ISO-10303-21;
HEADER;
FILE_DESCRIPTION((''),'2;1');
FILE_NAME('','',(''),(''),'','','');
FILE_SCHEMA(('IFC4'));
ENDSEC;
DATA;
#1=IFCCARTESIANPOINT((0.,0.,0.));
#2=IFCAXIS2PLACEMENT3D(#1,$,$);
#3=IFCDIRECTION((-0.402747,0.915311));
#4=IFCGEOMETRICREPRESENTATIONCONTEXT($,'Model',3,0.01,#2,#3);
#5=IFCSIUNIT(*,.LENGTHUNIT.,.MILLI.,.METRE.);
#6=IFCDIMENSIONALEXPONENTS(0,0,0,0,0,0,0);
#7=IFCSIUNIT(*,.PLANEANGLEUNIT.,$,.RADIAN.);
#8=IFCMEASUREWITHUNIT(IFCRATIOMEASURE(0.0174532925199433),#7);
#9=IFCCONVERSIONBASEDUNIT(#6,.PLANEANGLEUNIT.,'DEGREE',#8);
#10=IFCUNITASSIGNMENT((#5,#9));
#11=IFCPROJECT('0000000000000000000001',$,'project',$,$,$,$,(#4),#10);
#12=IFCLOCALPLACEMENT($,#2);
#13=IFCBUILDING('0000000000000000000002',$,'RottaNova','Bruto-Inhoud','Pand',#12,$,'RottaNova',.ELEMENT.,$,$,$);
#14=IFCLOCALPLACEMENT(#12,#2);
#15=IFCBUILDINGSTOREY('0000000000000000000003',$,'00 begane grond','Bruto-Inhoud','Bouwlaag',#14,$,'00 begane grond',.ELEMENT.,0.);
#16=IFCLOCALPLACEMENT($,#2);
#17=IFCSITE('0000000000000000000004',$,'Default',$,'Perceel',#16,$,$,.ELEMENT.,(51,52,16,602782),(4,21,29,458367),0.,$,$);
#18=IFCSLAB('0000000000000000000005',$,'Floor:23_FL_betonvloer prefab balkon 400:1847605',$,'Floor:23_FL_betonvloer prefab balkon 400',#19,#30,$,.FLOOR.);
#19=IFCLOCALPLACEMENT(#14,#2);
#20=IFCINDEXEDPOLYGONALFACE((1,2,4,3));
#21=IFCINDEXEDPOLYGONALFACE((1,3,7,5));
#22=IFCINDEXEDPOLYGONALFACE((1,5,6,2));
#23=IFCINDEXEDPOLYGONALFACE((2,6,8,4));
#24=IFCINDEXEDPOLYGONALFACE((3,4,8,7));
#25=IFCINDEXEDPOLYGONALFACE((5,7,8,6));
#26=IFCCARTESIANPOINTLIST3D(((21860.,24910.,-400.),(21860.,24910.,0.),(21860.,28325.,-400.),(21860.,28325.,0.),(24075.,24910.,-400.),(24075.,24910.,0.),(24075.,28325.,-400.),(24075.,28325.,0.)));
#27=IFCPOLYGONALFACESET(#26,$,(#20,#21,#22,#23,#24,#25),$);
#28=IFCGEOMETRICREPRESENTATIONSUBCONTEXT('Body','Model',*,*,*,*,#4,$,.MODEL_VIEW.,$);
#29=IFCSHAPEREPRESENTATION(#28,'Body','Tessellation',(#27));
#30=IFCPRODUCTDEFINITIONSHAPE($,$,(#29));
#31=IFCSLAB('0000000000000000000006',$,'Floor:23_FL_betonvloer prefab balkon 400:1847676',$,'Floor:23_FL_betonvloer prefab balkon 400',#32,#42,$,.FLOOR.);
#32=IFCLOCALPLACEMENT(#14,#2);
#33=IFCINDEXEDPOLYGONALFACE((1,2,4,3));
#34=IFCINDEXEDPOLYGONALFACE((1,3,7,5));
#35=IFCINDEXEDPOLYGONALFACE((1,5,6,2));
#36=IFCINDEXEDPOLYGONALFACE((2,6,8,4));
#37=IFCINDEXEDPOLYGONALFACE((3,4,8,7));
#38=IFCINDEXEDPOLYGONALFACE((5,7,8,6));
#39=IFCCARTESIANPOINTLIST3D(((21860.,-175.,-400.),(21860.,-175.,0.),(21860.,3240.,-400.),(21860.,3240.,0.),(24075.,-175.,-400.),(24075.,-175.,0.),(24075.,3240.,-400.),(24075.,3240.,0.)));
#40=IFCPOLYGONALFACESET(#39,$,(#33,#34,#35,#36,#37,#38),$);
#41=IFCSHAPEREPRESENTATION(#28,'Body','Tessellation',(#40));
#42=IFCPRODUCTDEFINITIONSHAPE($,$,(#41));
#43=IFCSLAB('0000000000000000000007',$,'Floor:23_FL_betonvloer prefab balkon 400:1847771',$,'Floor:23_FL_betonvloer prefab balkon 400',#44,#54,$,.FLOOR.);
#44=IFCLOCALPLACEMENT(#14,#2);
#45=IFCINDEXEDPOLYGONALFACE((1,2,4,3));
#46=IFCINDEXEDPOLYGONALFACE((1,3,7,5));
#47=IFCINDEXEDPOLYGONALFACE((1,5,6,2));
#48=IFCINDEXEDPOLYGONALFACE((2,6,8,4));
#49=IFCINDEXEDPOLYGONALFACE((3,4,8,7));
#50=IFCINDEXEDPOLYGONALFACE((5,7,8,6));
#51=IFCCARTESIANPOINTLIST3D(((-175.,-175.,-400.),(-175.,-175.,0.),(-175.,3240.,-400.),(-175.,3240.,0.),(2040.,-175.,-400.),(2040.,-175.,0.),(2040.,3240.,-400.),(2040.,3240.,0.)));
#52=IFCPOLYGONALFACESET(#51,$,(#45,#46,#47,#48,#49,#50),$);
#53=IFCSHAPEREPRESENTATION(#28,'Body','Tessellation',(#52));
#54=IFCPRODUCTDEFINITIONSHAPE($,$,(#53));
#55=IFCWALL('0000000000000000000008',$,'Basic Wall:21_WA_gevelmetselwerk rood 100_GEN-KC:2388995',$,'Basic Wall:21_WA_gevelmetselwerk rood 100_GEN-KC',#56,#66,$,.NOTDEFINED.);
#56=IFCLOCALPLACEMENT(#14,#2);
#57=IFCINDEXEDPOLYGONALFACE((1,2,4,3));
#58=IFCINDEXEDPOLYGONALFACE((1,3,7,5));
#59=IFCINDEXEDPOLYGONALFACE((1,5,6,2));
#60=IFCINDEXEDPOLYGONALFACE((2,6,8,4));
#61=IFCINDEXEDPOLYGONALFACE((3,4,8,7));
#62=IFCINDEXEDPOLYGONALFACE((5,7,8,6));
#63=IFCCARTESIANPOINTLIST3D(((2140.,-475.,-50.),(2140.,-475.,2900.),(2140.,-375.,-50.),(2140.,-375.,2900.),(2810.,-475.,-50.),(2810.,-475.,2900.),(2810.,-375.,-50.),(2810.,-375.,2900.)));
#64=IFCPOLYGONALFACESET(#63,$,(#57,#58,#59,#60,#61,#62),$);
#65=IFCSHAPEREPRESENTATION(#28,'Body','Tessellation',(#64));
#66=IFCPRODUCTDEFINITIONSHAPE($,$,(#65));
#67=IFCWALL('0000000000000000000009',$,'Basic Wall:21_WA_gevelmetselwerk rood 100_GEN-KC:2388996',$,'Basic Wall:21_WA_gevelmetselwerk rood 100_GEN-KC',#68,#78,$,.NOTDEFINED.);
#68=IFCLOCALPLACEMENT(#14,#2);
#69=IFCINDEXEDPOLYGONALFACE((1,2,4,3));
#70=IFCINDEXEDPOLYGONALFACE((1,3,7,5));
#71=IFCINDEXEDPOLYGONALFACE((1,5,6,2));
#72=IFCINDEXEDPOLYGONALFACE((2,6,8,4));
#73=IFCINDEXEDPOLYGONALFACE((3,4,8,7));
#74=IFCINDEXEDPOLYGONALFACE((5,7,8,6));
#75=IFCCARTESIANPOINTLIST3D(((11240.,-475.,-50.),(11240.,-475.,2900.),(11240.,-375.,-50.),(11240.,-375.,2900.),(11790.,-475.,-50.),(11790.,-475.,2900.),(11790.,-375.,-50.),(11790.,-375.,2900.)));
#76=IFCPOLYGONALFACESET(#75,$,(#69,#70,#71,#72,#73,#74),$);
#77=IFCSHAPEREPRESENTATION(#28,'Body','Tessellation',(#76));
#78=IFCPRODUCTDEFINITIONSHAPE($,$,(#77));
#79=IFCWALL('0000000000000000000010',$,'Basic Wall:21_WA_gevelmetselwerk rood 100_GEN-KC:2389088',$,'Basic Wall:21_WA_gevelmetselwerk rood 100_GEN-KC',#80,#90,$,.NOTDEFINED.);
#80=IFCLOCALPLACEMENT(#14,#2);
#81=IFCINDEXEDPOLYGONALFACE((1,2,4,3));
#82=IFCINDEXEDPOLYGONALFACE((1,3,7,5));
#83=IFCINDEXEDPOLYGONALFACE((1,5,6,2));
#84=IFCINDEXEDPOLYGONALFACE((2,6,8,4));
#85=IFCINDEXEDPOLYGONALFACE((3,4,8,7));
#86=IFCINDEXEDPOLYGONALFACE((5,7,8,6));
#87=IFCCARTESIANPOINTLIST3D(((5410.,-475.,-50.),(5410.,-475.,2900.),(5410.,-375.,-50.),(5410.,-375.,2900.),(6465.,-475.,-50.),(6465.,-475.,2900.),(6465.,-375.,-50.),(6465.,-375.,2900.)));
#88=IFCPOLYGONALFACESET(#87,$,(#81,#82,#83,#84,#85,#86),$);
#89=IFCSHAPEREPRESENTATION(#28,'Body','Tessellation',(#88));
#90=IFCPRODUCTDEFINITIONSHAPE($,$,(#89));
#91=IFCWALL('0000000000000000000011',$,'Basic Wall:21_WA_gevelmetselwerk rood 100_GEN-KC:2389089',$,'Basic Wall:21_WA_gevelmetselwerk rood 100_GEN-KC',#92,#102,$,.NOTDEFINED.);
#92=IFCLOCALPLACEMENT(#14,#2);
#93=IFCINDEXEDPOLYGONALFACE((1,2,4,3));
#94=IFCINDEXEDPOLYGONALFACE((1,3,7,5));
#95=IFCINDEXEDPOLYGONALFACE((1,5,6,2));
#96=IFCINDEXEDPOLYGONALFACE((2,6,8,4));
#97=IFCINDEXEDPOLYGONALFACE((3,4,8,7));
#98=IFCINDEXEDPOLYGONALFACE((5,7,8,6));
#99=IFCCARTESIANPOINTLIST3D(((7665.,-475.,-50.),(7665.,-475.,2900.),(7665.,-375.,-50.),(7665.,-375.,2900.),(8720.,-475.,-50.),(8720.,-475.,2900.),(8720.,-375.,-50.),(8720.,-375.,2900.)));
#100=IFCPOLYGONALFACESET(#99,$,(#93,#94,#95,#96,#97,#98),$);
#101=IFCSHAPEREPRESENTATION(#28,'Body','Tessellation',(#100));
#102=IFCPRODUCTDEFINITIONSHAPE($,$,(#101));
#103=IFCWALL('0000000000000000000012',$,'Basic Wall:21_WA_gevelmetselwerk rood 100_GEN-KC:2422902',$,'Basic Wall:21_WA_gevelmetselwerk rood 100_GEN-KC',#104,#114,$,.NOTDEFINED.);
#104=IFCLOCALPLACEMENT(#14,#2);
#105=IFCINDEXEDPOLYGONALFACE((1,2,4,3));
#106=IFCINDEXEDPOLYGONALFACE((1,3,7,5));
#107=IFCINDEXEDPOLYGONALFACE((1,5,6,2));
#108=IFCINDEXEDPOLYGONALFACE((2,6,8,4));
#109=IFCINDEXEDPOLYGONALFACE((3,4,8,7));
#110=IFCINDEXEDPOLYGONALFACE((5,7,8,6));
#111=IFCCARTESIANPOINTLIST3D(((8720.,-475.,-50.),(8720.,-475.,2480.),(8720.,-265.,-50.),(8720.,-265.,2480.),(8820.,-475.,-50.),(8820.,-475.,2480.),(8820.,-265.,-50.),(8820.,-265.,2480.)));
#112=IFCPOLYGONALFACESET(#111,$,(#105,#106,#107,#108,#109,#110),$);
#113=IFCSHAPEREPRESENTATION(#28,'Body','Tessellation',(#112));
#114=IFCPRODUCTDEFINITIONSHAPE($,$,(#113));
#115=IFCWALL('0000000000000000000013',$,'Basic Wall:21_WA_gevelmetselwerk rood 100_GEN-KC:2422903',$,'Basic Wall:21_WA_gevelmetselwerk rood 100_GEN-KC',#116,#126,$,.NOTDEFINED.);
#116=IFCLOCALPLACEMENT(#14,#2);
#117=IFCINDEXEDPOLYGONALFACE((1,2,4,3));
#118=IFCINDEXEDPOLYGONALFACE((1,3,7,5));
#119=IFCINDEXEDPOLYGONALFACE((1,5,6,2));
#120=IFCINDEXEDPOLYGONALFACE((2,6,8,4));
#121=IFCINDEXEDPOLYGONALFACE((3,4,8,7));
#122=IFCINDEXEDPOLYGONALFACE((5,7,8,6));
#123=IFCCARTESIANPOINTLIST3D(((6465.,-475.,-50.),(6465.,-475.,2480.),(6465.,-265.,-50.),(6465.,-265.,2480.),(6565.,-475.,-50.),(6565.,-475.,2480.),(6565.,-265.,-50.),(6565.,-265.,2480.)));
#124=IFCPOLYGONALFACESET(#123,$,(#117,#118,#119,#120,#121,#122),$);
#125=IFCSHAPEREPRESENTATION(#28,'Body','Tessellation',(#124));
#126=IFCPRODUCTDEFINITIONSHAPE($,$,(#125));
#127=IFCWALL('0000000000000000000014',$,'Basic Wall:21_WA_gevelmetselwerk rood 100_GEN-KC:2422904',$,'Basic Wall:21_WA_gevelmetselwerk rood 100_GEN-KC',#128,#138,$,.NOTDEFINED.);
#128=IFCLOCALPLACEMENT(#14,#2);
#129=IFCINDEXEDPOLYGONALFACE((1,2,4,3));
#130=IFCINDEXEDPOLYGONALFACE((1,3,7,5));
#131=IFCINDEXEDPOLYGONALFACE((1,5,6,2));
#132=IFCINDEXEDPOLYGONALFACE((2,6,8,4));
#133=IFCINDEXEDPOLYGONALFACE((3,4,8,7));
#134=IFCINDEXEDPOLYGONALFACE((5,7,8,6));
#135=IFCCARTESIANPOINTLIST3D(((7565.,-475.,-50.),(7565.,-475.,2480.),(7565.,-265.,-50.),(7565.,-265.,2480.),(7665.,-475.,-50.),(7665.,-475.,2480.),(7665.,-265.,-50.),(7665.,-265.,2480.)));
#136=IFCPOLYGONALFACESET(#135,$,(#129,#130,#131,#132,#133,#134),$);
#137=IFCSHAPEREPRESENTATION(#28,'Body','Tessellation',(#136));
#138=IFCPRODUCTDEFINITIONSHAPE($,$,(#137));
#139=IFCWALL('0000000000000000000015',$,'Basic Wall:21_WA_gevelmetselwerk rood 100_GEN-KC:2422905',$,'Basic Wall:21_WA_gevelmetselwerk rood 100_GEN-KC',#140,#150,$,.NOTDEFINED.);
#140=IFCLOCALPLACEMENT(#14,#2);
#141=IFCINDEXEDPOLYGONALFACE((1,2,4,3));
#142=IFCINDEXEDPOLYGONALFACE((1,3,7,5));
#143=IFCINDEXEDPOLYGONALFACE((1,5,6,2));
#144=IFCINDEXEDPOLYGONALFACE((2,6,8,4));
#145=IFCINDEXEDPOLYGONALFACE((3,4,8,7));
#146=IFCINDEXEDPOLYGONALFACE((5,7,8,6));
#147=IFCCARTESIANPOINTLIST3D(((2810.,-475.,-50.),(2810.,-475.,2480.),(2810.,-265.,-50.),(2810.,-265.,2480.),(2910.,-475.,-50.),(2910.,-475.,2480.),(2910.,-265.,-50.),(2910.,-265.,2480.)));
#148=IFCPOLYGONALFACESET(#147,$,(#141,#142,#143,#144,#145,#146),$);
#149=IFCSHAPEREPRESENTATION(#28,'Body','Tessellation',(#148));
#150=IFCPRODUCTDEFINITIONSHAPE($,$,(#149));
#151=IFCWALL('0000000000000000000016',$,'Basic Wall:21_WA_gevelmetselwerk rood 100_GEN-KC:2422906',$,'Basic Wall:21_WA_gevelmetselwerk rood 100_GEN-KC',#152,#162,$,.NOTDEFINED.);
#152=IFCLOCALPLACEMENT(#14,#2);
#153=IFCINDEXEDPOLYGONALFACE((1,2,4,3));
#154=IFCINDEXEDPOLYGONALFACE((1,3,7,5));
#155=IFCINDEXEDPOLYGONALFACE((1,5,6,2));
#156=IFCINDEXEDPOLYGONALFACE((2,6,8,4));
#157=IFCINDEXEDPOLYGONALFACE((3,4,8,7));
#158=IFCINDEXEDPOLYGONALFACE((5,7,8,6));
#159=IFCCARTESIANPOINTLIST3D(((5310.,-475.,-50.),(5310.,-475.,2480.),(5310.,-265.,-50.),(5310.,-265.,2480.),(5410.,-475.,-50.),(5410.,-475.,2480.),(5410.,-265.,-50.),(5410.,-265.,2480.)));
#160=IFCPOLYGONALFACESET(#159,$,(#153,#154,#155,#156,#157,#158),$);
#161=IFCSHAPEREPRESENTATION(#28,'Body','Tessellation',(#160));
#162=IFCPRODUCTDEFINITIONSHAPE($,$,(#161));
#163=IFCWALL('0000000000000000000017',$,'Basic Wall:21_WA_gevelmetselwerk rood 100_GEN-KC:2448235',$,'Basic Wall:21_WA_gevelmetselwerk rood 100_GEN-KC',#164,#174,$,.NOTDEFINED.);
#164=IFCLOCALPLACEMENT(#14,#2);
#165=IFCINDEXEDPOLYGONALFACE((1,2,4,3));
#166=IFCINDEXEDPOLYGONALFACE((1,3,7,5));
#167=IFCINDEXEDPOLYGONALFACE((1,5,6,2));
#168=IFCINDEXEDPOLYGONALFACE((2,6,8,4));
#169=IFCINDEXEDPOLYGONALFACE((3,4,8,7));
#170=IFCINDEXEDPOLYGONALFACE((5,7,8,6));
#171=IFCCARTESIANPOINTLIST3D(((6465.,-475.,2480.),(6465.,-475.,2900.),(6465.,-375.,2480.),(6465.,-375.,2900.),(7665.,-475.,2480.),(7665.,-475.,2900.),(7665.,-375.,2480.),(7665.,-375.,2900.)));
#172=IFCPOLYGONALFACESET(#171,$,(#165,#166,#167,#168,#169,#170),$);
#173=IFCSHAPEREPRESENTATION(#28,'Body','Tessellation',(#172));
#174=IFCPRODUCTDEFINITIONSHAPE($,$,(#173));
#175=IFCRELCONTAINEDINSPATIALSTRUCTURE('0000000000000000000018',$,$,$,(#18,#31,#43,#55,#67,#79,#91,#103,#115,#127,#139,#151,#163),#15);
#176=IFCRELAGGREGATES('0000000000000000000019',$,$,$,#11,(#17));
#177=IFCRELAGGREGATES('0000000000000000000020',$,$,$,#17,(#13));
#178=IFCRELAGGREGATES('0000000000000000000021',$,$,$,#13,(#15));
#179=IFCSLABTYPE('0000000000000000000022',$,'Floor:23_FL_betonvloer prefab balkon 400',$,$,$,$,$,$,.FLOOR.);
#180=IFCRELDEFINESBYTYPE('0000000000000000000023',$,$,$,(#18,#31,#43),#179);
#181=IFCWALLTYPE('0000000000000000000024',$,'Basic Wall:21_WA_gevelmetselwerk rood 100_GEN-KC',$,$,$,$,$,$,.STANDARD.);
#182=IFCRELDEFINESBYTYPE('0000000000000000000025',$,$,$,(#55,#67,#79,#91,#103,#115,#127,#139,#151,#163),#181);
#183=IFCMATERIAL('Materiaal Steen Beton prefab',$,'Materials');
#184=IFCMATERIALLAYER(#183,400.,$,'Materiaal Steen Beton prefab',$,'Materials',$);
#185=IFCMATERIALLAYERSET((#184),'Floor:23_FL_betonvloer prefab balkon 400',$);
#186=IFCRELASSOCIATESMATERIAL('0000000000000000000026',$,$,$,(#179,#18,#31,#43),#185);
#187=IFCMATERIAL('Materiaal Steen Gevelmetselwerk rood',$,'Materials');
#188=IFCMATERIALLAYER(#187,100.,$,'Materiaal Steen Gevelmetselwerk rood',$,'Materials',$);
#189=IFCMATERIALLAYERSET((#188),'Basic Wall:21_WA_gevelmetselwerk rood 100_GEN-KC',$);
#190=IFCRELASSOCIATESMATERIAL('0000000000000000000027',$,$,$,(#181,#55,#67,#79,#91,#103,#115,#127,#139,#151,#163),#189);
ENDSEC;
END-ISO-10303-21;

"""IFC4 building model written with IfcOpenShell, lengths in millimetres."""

from ifc_helpers import new_model, entity, si_unit, converted_unit, direction, frame, frame_2d, origin, place, context, subcontext, project, spatial, rectangle, extrude, material, layer, layer_set, layer_usage, type_object, element, save


model = new_model("IFC4")

# Units and contexts
model_context = context("Model", 3, precision=0.01, world=origin(), true_north=direction((-0.402747, 0.915311)))
body_context = subcontext(model_context, "Body", "Model", "MODEL_VIEW")
ifc_project = project(units=[si_unit("LENGTHUNIT", "METRE", prefix="MILLI"), converted_unit("PLANEANGLEUNIT", "DEGREE", entity("IfcRatioMeasure", 0.0174532925199433), si_unit("PLANEANGLEUNIT", "RADIAN"), dimensions=[0, 0, 0, 0, 0, 0, 0])], contexts=[model_context])

# Site, building, storey
site_placement = place(None, origin())
site = spatial("IfcSite", under=ifc_project, at=site_placement, Name="Default", ObjectType="Perceel", CompositionType="ELEMENT", RefLatitude=(51, 52, 16, 602782), RefLongitude=(4, 21, 29, 458367), RefElevation=0.0)
building_placement = place(None, origin())
building = spatial("IfcBuilding", under=site, at=building_placement, Name="RottaNova", Description="Bruto-Inhoud", ObjectType="Pand", LongName="RottaNova", CompositionType="ELEMENT")
storey_placement = place(building_placement, origin())
storey = spatial("IfcBuildingStorey", under=building, at=storey_placement, Name="00 begane grond", Description="Bruto-Inhoud", ObjectType="Bouwlaag", LongName="00 begane grond", CompositionType="ELEMENT", Elevation=0.0)

# Slabs
ifc_material_1 = material(Name="Materiaal Steen Beton prefab", Category="Materials")
ifc_layer_1 = layer(ifc_material_1, 400.0, Name="Materiaal Steen Beton prefab", Category="Materials")
ifc_layer_set_1 = layer_set([ifc_layer_1], Name="Floor:23_FL_betonvloer prefab balkon 400")
ifc_layer_usage = layer_usage(ifc_layer_set_1, "AXIS3", "POSITIVE", 0.0)
slab_type = type_object("IfcSlabType", Name="Floor:23_FL_betonvloer prefab balkon 400", PredefinedType="FLOOR", material=ifc_layer_set_1)
slab_1_placement = place(storey_placement, origin())
element("IfcSlab", 1, at=slab_1_placement, inside=storey, type_object=slab_type, material=ifc_layer_usage, Name="Floor:23_FL_betonvloer prefab balkon 400:1847605", ObjectType="Floor:23_FL_betonvloer prefab balkon 400", PredefinedType="FLOOR", context=body_context, shape_type="SweptSolid", body=[
    extrude(rectangle(XDim=3415.0, YDim=2215.0, at=frame_2d((0.0, 0.0), x_axis=(1.0, 0.0))), frame((22967.5, 26617.5, 0.0), z_axis=(0.0, 0.0, -1.0), x_axis=(0.0, 1.0, 0.0)), (0.0, 0.0, 1.0), 400.0),
])
slab_2_placement = place(storey_placement, origin())
element("IfcSlab", 2, at=slab_2_placement, inside=storey, type_object=slab_type, material=ifc_layer_usage, Name="Floor:23_FL_betonvloer prefab balkon 400:1847676", ObjectType="Floor:23_FL_betonvloer prefab balkon 400", PredefinedType="FLOOR", context=body_context, shape_type="SweptSolid", body=[
    extrude(rectangle(XDim=3415.0, YDim=2215.0, at=frame_2d((0.0, 0.0), x_axis=(1.0, 0.0))), frame((22967.5, 1532.5, 0.0), z_axis=(0.0, 0.0, -1.0), x_axis=(0.0, 1.0, 0.0)), (0.0, 0.0, 1.0), 400.0),
])
slab_3_placement = place(storey_placement, origin())
element("IfcSlab", 3, at=slab_3_placement, inside=storey, type_object=slab_type, material=ifc_layer_usage, Name="Floor:23_FL_betonvloer prefab balkon 400:1847771", ObjectType="Floor:23_FL_betonvloer prefab balkon 400", PredefinedType="FLOOR", context=body_context, shape_type="SweptSolid", body=[
    extrude(rectangle(XDim=3415.0, YDim=2215.0, at=frame_2d((0.0, 0.0), x_axis=(1.0, 0.0))), frame((932.5, 1532.5, 0.0), z_axis=(0.0, 0.0, -1.0), x_axis=(0.0, 1.0, 0.0)), (0.0, 0.0, 1.0), 400.0),
])

# Walls
ifc_material_2 = material(Name="Materiaal Steen Gevelmetselwerk rood", Category="Materials")
ifc_layer_2 = layer(ifc_material_2, 100.0, Name="Materiaal Steen Gevelmetselwerk rood", Category="Materials")
ifc_layer_set_2 = layer_set([ifc_layer_2], Name="Basic Wall:21_WA_gevelmetselwerk rood 100_GEN-KC")
wall_type_1 = type_object("IfcWallType", Name="Basic Wall:21_WA_gevelmetselwerk rood 100_GEN-KC", PredefinedType="STANDARD", material=ifc_layer_set_2)
wall_1_placement = place(storey_placement, frame((2140.0, -425.0, -50.0)))
element("IfcWall", 4, at=wall_1_placement, inside=storey, type_object=wall_type_1, material=ifc_layer_set_2, Name="Basic Wall:21_WA_gevelmetselwerk rood 100_GEN-KC:2388995", ObjectType="Basic Wall:21_WA_gevelmetselwerk rood 100_GEN-KC", PredefinedType="NOTDEFINED", context=body_context, shape_type="SweptSolid", body=[
    extrude(rectangle(XDim=670.0, YDim=100.0, at=frame_2d((335.0, 0.0), x_axis=(-1.0, 0.0))), origin(), (0.0, 0.0, 1.0), 2950.0),
])
wall_2_placement = place(storey_placement, frame((11240.0, -425.0, -50.0)))
element("IfcWall", 5, at=wall_2_placement, inside=storey, type_object=wall_type_1, material=ifc_layer_set_2, Name="Basic Wall:21_WA_gevelmetselwerk rood 100_GEN-KC:2388996", ObjectType="Basic Wall:21_WA_gevelmetselwerk rood 100_GEN-KC", PredefinedType="NOTDEFINED", context=body_context, shape_type="SweptSolid", body=[
    extrude(rectangle(XDim=550.0, YDim=100.0, at=frame_2d((275.0, 0.0), x_axis=(-1.0, 0.0))), origin(), (0.0, 0.0, 1.0), 2950.0),
])
wall_3_placement = place(storey_placement, frame((5410.0, -425.0, -50.0)))
element("IfcWall", 6, at=wall_3_placement, inside=storey, type_object=wall_type_1, material=ifc_layer_set_2, Name="Basic Wall:21_WA_gevelmetselwerk rood 100_GEN-KC:2389088", ObjectType="Basic Wall:21_WA_gevelmetselwerk rood 100_GEN-KC", PredefinedType="NOTDEFINED", context=body_context, shape_type="SweptSolid", body=[
    extrude(rectangle(XDim=1055.0, YDim=100.0, at=frame_2d((527.5, 0.0), x_axis=(-1.0, 0.0))), origin(), (0.0, 0.0, 1.0), 2950.0),
])
wall_4_placement = place(storey_placement, frame((7665.0, -425.0, -50.0)))
element("IfcWall", 7, at=wall_4_placement, inside=storey, type_object=wall_type_1, material=ifc_layer_set_2, Name="Basic Wall:21_WA_gevelmetselwerk rood 100_GEN-KC:2389089", ObjectType="Basic Wall:21_WA_gevelmetselwerk rood 100_GEN-KC", PredefinedType="NOTDEFINED", context=body_context, shape_type="SweptSolid", body=[
    extrude(rectangle(XDim=1055.0, YDim=100.0, at=frame_2d((527.5, 0.0), x_axis=(-1.0, 0.0))), origin(), (0.0, 0.0, 1.0), 2950.0),
])
wall_5_placement = place(storey_placement, frame((8770.0, -265.0, -50.0), z_axis=(0.0, 0.0, 1.0), x_axis=(0.0, -1.0, 0.0)))
element("IfcWall", 8, at=wall_5_placement, inside=storey, type_object=wall_type_1, material=ifc_layer_set_2, Name="Basic Wall:21_WA_gevelmetselwerk rood 100_GEN-KC:2422902", ObjectType="Basic Wall:21_WA_gevelmetselwerk rood 100_GEN-KC", PredefinedType="NOTDEFINED", context=body_context, shape_type="SweptSolid", body=[
    extrude(rectangle(XDim=210.0, YDim=100.0, at=frame_2d((105.0, 0.0), x_axis=(-1.0, 0.0))), origin(), (0.0, 0.0, 1.0), 2530.0),
])
wall_6_placement = place(storey_placement, frame((6515.0, -265.0, -50.0), z_axis=(0.0, 0.0, 1.0), x_axis=(0.0, -1.0, 0.0)))
element("IfcWall", 9, at=wall_6_placement, inside=storey, type_object=wall_type_1, material=ifc_layer_set_2, Name="Basic Wall:21_WA_gevelmetselwerk rood 100_GEN-KC:2422903", ObjectType="Basic Wall:21_WA_gevelmetselwerk rood 100_GEN-KC", PredefinedType="NOTDEFINED", context=body_context, shape_type="SweptSolid", body=[
    extrude(rectangle(XDim=210.0, YDim=100.0, at=frame_2d((105.0, 0.0), x_axis=(-1.0, 0.0))), origin(), (0.0, 0.0, 1.0), 2530.0),
])
wall_7_placement = place(storey_placement, frame((7615.0, -265.0, -50.0), z_axis=(0.0, 0.0, 1.0), x_axis=(0.0, -1.0, 0.0)))
element("IfcWall", 10, at=wall_7_placement, inside=storey, type_object=wall_type_1, material=ifc_layer_set_2, Name="Basic Wall:21_WA_gevelmetselwerk rood 100_GEN-KC:2422904", ObjectType="Basic Wall:21_WA_gevelmetselwerk rood 100_GEN-KC", PredefinedType="NOTDEFINED", context=body_context, shape_type="SweptSolid", body=[
    extrude(rectangle(XDim=210.0, YDim=100.0, at=frame_2d((105.0, 0.0), x_axis=(-1.0, 0.0))), origin(), (0.0, 0.0, 1.0), 2530.0),
])
wall_8_placement = place(storey_placement, frame((2860.0, -265.0, -50.0), z_axis=(0.0, 0.0, 1.0), x_axis=(0.0, -1.0, 0.0)))
element("IfcWall", 11, at=wall_8_placement, inside=storey, type_object=wall_type_1, material=ifc_layer_set_2, Name="Basic Wall:21_WA_gevelmetselwerk rood 100_GEN-KC:2422905", ObjectType="Basic Wall:21_WA_gevelmetselwerk rood 100_GEN-KC", PredefinedType="NOTDEFINED", context=body_context, shape_type="SweptSolid", body=[
    extrude(rectangle(XDim=210.0, YDim=100.0, at=frame_2d((105.0, 0.0), x_axis=(-1.0, 0.0))), origin(), (0.0, 0.0, 1.0), 2530.0),
])
wall_9_placement = place(storey_placement, frame((5360.0, -265.0, -50.0), z_axis=(0.0, 0.0, 1.0), x_axis=(0.0, -1.0, 0.0)))
element("IfcWall", 12, at=wall_9_placement, inside=storey, type_object=wall_type_1, material=ifc_layer_set_2, Name="Basic Wall:21_WA_gevelmetselwerk rood 100_GEN-KC:2422906", ObjectType="Basic Wall:21_WA_gevelmetselwerk rood 100_GEN-KC", PredefinedType="NOTDEFINED", context=body_context, shape_type="SweptSolid", body=[
    extrude(rectangle(XDim=210.0, YDim=100.0, at=frame_2d((105.0, 0.0), x_axis=(-1.0, 0.0))), origin(), (0.0, 0.0, 1.0), 2530.0),
])
wall_10_placement = place(storey_placement, frame((6465.0, -425.0, 2480.0)))
element("IfcWall", 13, at=wall_10_placement, inside=storey, type_object=wall_type_1, material=ifc_layer_set_2, Name="Basic Wall:21_WA_gevelmetselwerk rood 100_GEN-KC:2448235", ObjectType="Basic Wall:21_WA_gevelmetselwerk rood 100_GEN-KC", PredefinedType="NOTDEFINED", context=body_context, shape_type="SweptSolid", body=[
    extrude(rectangle(XDim=1200.0, YDim=100.0, at=frame_2d((600.0, 0.0), x_axis=(-1.0, 0.0))), origin(), (0.0, 0.0, 1.0), 420.0),
])

save(model, "model.ifc")
